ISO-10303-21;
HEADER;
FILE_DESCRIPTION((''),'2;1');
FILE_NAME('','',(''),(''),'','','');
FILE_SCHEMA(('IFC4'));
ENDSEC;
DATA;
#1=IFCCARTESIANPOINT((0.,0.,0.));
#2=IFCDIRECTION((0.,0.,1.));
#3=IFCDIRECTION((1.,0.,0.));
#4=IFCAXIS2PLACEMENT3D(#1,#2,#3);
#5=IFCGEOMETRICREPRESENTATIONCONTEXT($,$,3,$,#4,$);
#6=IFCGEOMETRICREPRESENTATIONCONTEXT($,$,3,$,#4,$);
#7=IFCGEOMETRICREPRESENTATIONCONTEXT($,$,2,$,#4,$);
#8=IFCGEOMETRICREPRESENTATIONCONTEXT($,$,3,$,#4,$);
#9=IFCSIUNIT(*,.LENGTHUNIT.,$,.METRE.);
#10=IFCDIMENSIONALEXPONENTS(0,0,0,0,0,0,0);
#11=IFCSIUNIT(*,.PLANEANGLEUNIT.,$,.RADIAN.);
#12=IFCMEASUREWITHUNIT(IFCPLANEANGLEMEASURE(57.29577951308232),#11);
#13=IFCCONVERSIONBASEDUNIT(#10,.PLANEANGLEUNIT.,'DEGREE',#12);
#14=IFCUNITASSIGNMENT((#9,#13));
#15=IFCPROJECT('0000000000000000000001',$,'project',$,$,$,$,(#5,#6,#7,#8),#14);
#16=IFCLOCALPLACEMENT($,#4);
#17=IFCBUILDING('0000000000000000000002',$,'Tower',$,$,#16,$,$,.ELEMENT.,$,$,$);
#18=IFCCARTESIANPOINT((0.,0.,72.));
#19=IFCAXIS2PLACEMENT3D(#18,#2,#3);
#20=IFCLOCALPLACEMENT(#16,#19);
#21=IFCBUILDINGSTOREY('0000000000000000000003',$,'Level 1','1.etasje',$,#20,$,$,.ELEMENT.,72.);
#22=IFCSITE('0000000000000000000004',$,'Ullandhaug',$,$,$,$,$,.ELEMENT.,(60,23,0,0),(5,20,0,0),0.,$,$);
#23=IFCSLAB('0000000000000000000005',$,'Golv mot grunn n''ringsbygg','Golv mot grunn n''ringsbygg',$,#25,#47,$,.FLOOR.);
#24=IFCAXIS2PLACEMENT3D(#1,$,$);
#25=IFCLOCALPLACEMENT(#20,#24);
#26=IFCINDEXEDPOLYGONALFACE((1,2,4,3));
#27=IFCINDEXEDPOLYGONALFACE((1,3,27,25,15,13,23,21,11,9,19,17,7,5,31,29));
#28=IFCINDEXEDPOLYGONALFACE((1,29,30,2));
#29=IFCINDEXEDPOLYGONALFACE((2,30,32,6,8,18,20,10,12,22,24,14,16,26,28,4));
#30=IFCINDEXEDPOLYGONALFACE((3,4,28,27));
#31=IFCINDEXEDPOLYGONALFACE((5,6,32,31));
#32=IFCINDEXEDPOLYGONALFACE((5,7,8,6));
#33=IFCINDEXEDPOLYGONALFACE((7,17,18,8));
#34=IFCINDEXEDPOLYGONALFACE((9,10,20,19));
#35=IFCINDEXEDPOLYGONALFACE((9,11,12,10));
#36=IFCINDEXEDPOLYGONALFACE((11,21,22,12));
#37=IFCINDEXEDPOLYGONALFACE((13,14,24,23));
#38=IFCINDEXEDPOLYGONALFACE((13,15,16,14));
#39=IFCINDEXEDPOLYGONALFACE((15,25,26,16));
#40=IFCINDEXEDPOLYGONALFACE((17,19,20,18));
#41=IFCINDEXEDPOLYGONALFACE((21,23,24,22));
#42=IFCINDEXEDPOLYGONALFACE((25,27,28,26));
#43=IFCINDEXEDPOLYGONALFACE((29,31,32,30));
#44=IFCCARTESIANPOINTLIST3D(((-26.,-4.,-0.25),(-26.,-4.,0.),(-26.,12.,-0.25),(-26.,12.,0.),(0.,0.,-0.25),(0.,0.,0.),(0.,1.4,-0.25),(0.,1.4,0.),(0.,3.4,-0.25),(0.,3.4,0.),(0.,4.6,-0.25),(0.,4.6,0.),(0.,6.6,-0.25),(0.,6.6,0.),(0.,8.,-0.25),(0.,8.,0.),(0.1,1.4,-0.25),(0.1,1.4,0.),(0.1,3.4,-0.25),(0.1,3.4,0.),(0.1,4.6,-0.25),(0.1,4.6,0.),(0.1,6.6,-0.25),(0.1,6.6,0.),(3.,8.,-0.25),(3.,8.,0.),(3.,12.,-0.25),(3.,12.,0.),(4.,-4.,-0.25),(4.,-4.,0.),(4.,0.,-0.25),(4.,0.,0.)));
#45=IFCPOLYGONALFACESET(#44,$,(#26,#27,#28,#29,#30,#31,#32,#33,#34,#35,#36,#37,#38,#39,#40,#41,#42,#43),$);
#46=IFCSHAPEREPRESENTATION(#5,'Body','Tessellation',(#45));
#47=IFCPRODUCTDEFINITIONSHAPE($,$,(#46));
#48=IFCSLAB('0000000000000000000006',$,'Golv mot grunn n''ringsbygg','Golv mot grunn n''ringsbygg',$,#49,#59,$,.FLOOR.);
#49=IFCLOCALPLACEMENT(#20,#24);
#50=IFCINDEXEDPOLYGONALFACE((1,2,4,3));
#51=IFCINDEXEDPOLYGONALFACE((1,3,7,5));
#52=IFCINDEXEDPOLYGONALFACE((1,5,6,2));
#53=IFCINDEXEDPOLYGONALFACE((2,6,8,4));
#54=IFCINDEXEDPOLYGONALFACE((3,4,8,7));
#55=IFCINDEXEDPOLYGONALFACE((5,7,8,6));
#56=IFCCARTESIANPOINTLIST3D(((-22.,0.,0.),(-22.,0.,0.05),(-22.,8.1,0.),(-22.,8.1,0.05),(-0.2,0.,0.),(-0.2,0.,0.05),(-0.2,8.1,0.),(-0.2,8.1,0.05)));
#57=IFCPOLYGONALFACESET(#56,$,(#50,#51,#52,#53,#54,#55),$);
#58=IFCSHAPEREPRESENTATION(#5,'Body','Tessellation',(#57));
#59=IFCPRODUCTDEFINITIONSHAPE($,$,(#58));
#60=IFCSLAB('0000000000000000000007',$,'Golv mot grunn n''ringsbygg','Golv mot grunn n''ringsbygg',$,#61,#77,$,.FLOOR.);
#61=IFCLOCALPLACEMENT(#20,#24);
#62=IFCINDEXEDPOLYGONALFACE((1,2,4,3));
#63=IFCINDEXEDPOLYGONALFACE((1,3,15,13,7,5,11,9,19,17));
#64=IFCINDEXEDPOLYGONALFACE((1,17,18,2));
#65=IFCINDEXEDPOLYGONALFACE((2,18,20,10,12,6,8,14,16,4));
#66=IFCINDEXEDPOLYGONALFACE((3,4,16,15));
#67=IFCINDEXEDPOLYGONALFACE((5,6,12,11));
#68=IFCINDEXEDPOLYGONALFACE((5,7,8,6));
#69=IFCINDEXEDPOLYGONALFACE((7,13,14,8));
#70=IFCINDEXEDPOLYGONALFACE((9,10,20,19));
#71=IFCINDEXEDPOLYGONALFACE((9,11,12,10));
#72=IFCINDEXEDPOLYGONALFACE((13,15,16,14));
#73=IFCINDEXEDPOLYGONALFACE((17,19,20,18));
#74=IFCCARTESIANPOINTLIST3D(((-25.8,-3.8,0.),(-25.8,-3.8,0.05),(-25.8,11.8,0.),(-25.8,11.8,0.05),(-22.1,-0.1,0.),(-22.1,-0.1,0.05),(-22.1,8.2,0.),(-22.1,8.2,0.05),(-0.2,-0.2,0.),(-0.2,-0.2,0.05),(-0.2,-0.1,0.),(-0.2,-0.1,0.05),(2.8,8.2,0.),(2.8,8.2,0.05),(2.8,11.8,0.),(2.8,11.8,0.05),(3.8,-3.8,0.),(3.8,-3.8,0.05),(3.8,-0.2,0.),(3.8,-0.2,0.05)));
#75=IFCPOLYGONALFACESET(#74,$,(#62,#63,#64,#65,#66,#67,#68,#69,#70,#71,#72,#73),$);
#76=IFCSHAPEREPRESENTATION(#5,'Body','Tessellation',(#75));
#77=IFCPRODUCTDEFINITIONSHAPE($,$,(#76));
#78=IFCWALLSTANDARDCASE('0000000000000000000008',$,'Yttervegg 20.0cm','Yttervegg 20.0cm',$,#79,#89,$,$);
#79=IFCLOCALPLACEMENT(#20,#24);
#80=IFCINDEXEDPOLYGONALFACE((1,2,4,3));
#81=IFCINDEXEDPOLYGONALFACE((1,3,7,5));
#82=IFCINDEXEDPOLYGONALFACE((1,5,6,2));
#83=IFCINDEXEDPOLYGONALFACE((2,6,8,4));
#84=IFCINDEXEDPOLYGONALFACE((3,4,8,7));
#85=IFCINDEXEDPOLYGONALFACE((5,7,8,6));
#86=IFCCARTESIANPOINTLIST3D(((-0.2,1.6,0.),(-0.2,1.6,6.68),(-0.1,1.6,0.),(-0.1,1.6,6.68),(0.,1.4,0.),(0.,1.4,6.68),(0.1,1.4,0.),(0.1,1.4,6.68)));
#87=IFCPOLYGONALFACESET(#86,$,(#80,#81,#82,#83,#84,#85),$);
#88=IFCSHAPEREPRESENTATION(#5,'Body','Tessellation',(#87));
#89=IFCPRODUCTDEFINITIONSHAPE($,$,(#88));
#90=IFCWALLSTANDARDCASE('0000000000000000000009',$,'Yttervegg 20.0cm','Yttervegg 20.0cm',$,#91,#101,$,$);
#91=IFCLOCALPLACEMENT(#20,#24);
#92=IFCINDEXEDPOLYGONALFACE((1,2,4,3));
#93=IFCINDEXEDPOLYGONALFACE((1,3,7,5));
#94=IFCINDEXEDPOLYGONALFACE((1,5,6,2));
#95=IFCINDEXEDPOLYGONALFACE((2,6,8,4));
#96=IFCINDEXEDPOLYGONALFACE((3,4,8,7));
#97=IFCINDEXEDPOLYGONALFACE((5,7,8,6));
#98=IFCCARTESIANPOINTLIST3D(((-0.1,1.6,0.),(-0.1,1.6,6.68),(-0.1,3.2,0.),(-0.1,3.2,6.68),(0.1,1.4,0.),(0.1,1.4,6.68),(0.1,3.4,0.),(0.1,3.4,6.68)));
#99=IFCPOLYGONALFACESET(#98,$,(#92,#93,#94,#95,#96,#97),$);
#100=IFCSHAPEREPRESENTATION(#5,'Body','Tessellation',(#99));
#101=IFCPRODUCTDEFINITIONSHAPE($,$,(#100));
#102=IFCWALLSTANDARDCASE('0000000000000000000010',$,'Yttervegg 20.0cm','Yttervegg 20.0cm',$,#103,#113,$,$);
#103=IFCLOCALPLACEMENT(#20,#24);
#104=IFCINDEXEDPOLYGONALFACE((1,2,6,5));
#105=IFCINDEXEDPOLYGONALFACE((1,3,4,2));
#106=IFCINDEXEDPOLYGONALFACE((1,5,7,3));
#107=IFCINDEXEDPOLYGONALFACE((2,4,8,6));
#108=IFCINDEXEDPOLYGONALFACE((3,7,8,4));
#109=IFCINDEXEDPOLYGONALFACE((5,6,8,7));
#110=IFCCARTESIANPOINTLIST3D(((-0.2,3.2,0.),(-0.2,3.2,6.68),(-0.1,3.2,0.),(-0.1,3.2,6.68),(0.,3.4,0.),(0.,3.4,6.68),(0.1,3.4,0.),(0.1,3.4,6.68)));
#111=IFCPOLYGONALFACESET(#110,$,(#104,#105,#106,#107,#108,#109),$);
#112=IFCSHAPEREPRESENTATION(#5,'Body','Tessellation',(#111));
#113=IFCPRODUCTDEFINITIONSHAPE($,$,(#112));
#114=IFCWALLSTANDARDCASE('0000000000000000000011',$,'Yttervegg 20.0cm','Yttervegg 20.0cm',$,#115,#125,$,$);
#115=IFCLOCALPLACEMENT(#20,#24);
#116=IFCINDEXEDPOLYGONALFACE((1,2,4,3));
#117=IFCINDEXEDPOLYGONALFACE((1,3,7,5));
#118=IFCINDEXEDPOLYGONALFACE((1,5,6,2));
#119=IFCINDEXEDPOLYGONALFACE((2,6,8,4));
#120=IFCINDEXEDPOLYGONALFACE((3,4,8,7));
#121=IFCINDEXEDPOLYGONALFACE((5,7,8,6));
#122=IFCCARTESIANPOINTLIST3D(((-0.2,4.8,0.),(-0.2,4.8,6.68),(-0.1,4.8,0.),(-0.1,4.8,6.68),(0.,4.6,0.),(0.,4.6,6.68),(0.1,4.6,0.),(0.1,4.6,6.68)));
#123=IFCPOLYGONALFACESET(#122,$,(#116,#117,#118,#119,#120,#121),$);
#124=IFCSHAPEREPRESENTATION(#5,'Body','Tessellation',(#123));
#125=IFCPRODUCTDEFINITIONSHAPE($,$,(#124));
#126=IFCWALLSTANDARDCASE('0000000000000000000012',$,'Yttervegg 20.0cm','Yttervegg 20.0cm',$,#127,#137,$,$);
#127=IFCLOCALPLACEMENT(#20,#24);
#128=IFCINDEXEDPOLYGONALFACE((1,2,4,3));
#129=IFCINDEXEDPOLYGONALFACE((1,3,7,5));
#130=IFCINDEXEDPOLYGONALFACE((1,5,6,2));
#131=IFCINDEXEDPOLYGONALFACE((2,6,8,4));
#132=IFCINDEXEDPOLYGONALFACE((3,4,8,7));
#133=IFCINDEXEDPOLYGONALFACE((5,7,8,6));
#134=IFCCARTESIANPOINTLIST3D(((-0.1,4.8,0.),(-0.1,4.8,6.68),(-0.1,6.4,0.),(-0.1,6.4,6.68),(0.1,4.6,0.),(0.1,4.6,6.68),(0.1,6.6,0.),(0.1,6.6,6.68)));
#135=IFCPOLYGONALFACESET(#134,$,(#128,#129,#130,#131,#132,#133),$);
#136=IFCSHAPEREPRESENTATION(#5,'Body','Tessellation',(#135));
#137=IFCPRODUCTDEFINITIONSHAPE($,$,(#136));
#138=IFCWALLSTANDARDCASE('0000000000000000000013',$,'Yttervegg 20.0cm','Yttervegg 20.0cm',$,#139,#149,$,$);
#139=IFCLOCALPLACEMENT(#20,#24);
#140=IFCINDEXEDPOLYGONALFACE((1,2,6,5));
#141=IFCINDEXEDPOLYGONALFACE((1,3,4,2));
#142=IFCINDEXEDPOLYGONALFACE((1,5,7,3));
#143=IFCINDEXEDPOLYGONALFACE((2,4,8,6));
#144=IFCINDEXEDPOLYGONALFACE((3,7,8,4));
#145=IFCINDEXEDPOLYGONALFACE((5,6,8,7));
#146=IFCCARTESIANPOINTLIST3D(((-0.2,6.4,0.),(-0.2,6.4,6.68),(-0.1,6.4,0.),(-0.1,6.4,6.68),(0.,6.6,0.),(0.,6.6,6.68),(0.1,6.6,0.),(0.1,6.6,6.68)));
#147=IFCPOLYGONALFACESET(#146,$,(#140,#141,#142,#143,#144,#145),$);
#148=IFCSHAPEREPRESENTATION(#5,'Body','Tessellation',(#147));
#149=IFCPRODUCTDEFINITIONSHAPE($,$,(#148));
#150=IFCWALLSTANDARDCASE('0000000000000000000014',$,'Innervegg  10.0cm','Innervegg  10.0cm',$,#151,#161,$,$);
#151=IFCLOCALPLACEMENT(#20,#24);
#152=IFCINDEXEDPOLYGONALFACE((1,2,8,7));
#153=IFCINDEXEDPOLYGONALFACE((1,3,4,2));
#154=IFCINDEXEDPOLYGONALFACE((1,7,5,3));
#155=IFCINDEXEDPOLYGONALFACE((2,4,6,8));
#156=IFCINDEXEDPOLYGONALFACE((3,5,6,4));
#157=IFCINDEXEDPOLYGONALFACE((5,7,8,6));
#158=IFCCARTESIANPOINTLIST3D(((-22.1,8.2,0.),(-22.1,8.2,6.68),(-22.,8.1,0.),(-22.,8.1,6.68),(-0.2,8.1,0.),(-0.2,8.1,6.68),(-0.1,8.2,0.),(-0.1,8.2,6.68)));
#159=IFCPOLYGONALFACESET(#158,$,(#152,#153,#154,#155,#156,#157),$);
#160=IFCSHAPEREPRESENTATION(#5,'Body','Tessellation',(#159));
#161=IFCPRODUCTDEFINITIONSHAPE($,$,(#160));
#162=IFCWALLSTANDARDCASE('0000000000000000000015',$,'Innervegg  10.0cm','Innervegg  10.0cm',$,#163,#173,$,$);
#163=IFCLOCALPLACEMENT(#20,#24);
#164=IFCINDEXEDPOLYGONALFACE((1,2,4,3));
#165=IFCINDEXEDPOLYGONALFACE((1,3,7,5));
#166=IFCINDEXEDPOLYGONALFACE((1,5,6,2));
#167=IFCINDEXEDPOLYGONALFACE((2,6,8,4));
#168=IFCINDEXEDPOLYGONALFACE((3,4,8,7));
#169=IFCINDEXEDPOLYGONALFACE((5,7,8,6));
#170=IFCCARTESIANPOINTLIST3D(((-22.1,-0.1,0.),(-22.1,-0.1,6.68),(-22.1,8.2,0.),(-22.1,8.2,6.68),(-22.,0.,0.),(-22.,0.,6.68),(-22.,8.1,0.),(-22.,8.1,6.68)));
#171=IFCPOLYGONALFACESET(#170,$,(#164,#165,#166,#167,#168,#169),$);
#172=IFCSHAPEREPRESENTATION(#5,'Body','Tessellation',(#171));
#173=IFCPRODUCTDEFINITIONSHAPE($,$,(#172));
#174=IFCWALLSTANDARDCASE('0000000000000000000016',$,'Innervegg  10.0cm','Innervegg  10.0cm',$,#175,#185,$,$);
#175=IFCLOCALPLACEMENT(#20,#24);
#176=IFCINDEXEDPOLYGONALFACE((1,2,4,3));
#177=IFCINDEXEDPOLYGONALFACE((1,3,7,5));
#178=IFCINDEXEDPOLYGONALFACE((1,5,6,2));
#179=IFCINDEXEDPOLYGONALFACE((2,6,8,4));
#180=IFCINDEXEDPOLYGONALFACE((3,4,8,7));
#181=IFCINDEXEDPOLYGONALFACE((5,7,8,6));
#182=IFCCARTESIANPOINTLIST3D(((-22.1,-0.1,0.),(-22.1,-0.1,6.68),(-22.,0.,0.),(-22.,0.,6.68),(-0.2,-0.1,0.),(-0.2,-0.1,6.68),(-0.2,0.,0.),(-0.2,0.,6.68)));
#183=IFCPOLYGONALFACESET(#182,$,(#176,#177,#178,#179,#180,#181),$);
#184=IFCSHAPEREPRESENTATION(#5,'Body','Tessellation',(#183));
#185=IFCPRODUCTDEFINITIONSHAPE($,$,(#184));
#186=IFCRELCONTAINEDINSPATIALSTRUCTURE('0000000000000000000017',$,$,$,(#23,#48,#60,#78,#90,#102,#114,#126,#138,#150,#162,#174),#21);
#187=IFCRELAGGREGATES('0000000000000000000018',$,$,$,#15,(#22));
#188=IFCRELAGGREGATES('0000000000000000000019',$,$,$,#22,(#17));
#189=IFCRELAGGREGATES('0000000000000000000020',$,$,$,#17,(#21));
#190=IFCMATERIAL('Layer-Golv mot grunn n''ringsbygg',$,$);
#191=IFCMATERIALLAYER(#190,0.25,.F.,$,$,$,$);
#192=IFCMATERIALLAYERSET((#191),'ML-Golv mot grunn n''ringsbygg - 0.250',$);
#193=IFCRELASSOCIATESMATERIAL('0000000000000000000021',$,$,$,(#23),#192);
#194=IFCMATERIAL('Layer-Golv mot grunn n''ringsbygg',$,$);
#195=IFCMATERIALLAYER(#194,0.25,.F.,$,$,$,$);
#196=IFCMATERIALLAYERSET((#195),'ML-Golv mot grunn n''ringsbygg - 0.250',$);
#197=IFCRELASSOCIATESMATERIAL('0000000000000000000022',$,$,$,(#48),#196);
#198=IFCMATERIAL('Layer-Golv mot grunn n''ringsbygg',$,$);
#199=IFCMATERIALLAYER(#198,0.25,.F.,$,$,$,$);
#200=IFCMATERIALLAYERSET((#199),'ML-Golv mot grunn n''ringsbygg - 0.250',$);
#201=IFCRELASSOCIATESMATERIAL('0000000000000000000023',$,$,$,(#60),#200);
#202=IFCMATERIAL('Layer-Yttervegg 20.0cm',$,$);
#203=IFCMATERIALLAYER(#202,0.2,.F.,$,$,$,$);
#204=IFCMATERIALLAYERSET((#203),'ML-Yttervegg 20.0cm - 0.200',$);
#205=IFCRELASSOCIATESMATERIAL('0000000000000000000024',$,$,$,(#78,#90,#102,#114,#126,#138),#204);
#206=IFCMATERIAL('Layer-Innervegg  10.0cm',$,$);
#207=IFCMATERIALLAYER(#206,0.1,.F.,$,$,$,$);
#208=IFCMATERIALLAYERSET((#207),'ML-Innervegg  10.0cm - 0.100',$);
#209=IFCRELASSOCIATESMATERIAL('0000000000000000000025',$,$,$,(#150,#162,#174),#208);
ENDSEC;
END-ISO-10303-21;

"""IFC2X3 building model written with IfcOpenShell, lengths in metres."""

from ifc_helpers import new_model, entity, si_unit, converted_unit, frame, origin_with_axes, place, context, project, spatial, polyline, outline, extrude, material, layer, layer_set, layer_usage, element, save


model = new_model("IFC2X3")

# Units and contexts
context_of_model_1 = context(None, 3, world=origin_with_axes())
context_of_model_2 = context(None, 3, world=origin_with_axes())
context_of_model_3 = context(None, 2, world=origin_with_axes())
context_of_model_4 = context(None, 3, world=origin_with_axes())
ifc_project = project(units=[si_unit("LENGTHUNIT", "METRE"), converted_unit("PLANEANGLEUNIT", "DEGREE", entity("IfcPlaneAngleMeasure", 57.29577951308232), si_unit("PLANEANGLEUNIT", "RADIAN"), dimensions=[0, 0, 0, 0, 0, 0, 0])], contexts=[context_of_model_1, context_of_model_2, context_of_model_3, context_of_model_4])

# Site, building, storey
site = spatial("IfcSite", under=ifc_project, Name="Ullandhaug", CompositionType="ELEMENT", RefLatitude=(60, 23, 0, 0), RefLongitude=(5, 20, 0, 0), RefElevation=0.0)
building_placement = place(None, origin_with_axes())
building = spatial("IfcBuilding", under=site, at=building_placement, Name="Tower", CompositionType="ELEMENT")
storey_placement = place(building_placement, frame((0.0, 0.0, 72.0), z_axis=(0.0, 0.0, 1.0), x_axis=(1.0, 0.0, 0.0)))
storey = spatial("IfcBuildingStorey", under=building, at=storey_placement, Name="Level 1", Description="1.etasje", CompositionType="ELEMENT", Elevation=72.0)

# Slabs
ifc_material_1 = material(Name="Layer-Golv mot grunn n'ringsbygg")
ifc_layer_1 = layer(ifc_material_1, 0.25, ventilated=False)
ifc_layer_set_1 = layer_set([ifc_layer_1], Name="ML-Golv mot grunn n'ringsbygg - 0.250")
ifc_layer_usage_1 = layer_usage(ifc_layer_set_1, "AXIS2", "POSITIVE", 0.0)
slab_1_placement = place(storey_placement, frame((-26.0, -4.0, 0.0), z_axis=(0.0, 0.0, 1.0), x_axis=(1.0, 0.0, 0.0)))
element("IfcSlab", 1, at=slab_1_placement, inside=storey, material=ifc_layer_usage_1, Name="Golv mot grunn n'ringsbygg", Description="Golv mot grunn n'ringsbygg", PredefinedType="FLOOR", context=context_of_model_1, shape_type="SweptSolid", body=[
    extrude(outline(polyline([(0.0, 0.0), (30.0, 0.0), (30.0, 4.0), (26.0, 4.0), (26.0, 5.4), (26.1, 5.4), (26.1, 7.4), (26.0, 7.4), (26.0, 8.6), (26.1, 8.6), (26.1, 10.6), (26.0, 10.6), (26.0, 12.0), (29.0, 12.0), (29.0, 16.0), (0.0, 16.0), (0.0, 0.0)])), origin_with_axes(), (0.0, 0.0, -1.0), 0.25),
])
ifc_material_2 = material(Name="Layer-Golv mot grunn n'ringsbygg")
ifc_layer_2 = layer(ifc_material_2, 0.25, ventilated=False)
ifc_layer_set_2 = layer_set([ifc_layer_2], Name="ML-Golv mot grunn n'ringsbygg - 0.250")
ifc_layer_usage_2 = layer_usage(ifc_layer_set_2, "AXIS2", "POSITIVE", 0.0)
slab_2_placement = place(storey_placement, frame((-0.2, 8.1, 0.0), z_axis=(0.0, 0.0, 1.0), x_axis=(1.0, 0.0, 0.0)))
element("IfcSlab", 2, at=slab_2_placement, inside=storey, material=ifc_layer_usage_2, Name="Golv mot grunn n'ringsbygg", Description="Golv mot grunn n'ringsbygg", PredefinedType="FLOOR", context=context_of_model_1, shape_type="SweptSolid", body=[
    extrude(outline(polyline([(0.0, 0.0), (21.8, 0.0), (21.8, 8.1), (0.0, 8.1), (0.0, 0.0)])), frame((0.0, 0.0, 0.0), z_axis=(0.0, 0.0, 1.0), x_axis=(-1.0, 0.0, 0.0)), (0.0, 0.0, 1.0), 0.05),
])
ifc_material_3 = material(Name="Layer-Golv mot grunn n'ringsbygg")
ifc_layer_3 = layer(ifc_material_3, 0.25, ventilated=False)
ifc_layer_set_3 = layer_set([ifc_layer_3], Name="ML-Golv mot grunn n'ringsbygg - 0.250")
ifc_layer_usage_3 = layer_usage(ifc_layer_set_3, "AXIS2", "POSITIVE", 0.0)
slab_3_placement = place(storey_placement, frame((-25.8, -3.8, 0.0), z_axis=(0.0, 0.0, 1.0), x_axis=(1.0, 0.0, 0.0)))
element("IfcSlab", 3, at=slab_3_placement, inside=storey, material=ifc_layer_usage_3, Name="Golv mot grunn n'ringsbygg", Description="Golv mot grunn n'ringsbygg", PredefinedType="FLOOR", context=context_of_model_1, shape_type="SweptSolid", body=[
    extrude(outline(polyline([(0.0, 0.0), (29.6, 0.0), (29.6, 3.6), (25.6, 3.6), (25.6, 3.7), (3.7, 3.7), (3.7, 12.0), (28.6, 12.0), (28.6, 15.6), (0.0, 15.6), (0.0, 0.0)])), origin_with_axes(), (0.0, 0.0, 1.0), 0.05),
])

# Walls
ifc_material_4 = material(Name="Layer-Yttervegg 20.0cm")
ifc_layer_4 = layer(ifc_material_4, 0.2, ventilated=False)
ifc_layer_set_4 = layer_set([ifc_layer_4], Name="ML-Yttervegg 20.0cm - 0.200")
ifc_layer_usage_4 = layer_usage(ifc_layer_set_4, "AXIS2", "POSITIVE", 0.0)
wall_1_placement = place(storey_placement, frame((0.0, 1.4, 0.0), z_axis=(0.0, 0.0, 1.0), x_axis=(1.0, 0.0, 0.0)))
element("IfcWallStandardCase", 4, at=wall_1_placement, inside=storey, material=ifc_layer_usage_4, Name="Yttervegg 20.0cm", Description="Yttervegg 20.0cm", context=context_of_model_1, shape_type="SweptSolid", body=[
    extrude(outline(polyline([(0.0, 0.0), (0.1, 0.0), (-0.1, 0.2), (-0.2, 0.2), (0.0, 0.0)])), origin_with_axes(), (0.0, 0.0, 1.0), 6.68),
])
wall_2_placement = place(storey_placement, frame((0.1, 1.4, 0.0), z_axis=(0.0, 0.0, 1.0), x_axis=(0.0, 1.0, 0.0)))
element("IfcWallStandardCase", 5, at=wall_2_placement, inside=storey, material=ifc_layer_usage_4, Name="Yttervegg 20.0cm", Description="Yttervegg 20.0cm", context=context_of_model_1, shape_type="SweptSolid", body=[
    extrude(outline(polyline([(0.0, 0.0), (2.0, 0.0), (1.8, 0.2), (0.2, 0.2), (0.0, 0.0)])), frame((0.0, 0.0, 0.0), z_axis=(0.0, 0.0, 1.0), x_axis=(1.0, 0.0, 0.0)), (0.0, 0.0, 1.0), 6.68),
])
wall_3_placement = place(storey_placement, frame((0.1, 3.4, 0.0), z_axis=(0.0, 0.0, 1.0), x_axis=(-1.0, 0.0, 0.0)))
element("IfcWallStandardCase", 6, at=wall_3_placement, inside=storey, material=ifc_layer_usage_4, Name="Yttervegg 20.0cm", Description="Yttervegg 20.0cm", context=context_of_model_1, shape_type="SweptSolid", body=[
    extrude(outline(polyline([(0.0, 0.0), (0.1, 0.0), (0.3, 0.2), (0.2, 0.2), (0.0, 0.0)])), frame((0.0, 0.0, 0.0), z_axis=(0.0, 0.0, 1.0), x_axis=(1.0, 0.0, 0.0)), (0.0, 0.0, 1.0), 6.68),
])
wall_4_placement = place(storey_placement, frame((0.0, 4.6, 0.0), z_axis=(0.0, 0.0, 1.0), x_axis=(1.0, 0.0, 0.0)))
element("IfcWallStandardCase", 7, at=wall_4_placement, inside=storey, material=ifc_layer_usage_4, Name="Yttervegg 20.0cm", Description="Yttervegg 20.0cm", context=context_of_model_1, shape_type="SweptSolid", body=[
    extrude(outline(polyline([(0.0, 0.0), (0.1, 0.0), (-0.1, 0.2), (-0.2, 0.2), (0.0, 0.0)])), origin_with_axes(), (0.0, 0.0, 1.0), 6.68),
])
wall_5_placement = place(storey_placement, frame((0.1, 4.6, 0.0), z_axis=(0.0, 0.0, 1.0), x_axis=(0.0, 1.0, 0.0)))
element("IfcWallStandardCase", 8, at=wall_5_placement, inside=storey, material=ifc_layer_usage_4, Name="Yttervegg 20.0cm", Description="Yttervegg 20.0cm", context=context_of_model_1, shape_type="SweptSolid", body=[
    extrude(outline(polyline([(0.0, 0.0), (2.0, 0.0), (1.8, 0.2), (0.2, 0.2), (0.0, 0.0)])), frame((0.0, 0.0, 0.0), z_axis=(0.0, 0.0, 1.0), x_axis=(1.0, 0.0, 0.0)), (0.0, 0.0, 1.0), 6.68),
])
wall_6_placement = place(storey_placement, frame((0.1, 6.6, 0.0), z_axis=(0.0, 0.0, 1.0), x_axis=(-1.0, 0.0, 0.0)))
element("IfcWallStandardCase", 9, at=wall_6_placement, inside=storey, material=ifc_layer_usage_4, Name="Yttervegg 20.0cm", Description="Yttervegg 20.0cm", context=context_of_model_1, shape_type="SweptSolid", body=[
    extrude(outline(polyline([(0.0, 0.0), (0.1, 0.0), (0.3, 0.2), (0.2, 0.2), (0.0, 0.0)])), frame((0.0, 0.0, 0.0), z_axis=(0.0, 0.0, 1.0), x_axis=(1.0, 0.0, 0.0)), (0.0, 0.0, 1.0), 6.68),
])
ifc_material_5 = material(Name="Layer-Innervegg  10.0cm")
ifc_layer_5 = layer(ifc_material_5, 0.1, ventilated=False)
ifc_layer_set_5 = layer_set([ifc_layer_5], Name="ML-Innervegg  10.0cm - 0.100")
ifc_layer_usage_5 = layer_usage(ifc_layer_set_5, "AXIS2", "POSITIVE", 0.0)
wall_7_placement = place(storey_placement, frame((-0.1, 8.2, 0.0), z_axis=(0.0, 0.0, 1.0), x_axis=(-1.0, 0.0, 0.0)))
element("IfcWallStandardCase", 10, at=wall_7_placement, inside=storey, material=ifc_layer_usage_5, Name="Innervegg  10.0cm", Description="Innervegg  10.0cm", context=context_of_model_1, shape_type="SweptSolid", body=[
    extrude(outline(polyline([(0.0, 0.0), (22.0, 0.0), (21.9, 0.1), (0.1, 0.1), (0.0, 0.0)])), frame((0.0, 0.0, 0.0), z_axis=(0.0, 0.0, 1.0), x_axis=(1.0, 0.0, 0.0)), (0.0, 0.0, 1.0), 6.68),
])
wall_8_placement = place(storey_placement, frame((-22.1, 8.2, 0.0), z_axis=(0.0, 0.0, 1.0), x_axis=(0.0, -1.0, 0.0)))
element("IfcWallStandardCase", 11, at=wall_8_placement, inside=storey, material=ifc_layer_usage_5, Name="Innervegg  10.0cm", Description="Innervegg  10.0cm", context=context_of_model_1, shape_type="SweptSolid", body=[
    extrude(outline(polyline([(0.0, 0.0), (8.3, 0.0), (8.2, 0.1), (0.1, 0.1), (0.0, 0.0)])), frame((0.0, 0.0, 0.0), z_axis=(0.0, 0.0, 1.0), x_axis=(1.0, 0.0, 0.0)), (0.0, 0.0, 1.0), 6.68),
])
wall_9_placement = place(storey_placement, frame((-22.1, -0.1, 0.0), z_axis=(0.0, 0.0, 1.0), x_axis=(1.0, 0.0, 0.0)))
element("IfcWallStandardCase", 12, at=wall_9_placement, inside=storey, material=ifc_layer_usage_5, Name="Innervegg  10.0cm", Description="Innervegg  10.0cm", context=context_of_model_1, shape_type="SweptSolid", body=[
    extrude(outline(polyline([(0.0, 0.0), (21.9, 0.0), (21.9, 0.1), (0.1, 0.1), (0.0, 0.0)])), origin_with_axes(), (0.0, 0.0, 1.0), 6.68),
])

save(model, "model.ifc")
